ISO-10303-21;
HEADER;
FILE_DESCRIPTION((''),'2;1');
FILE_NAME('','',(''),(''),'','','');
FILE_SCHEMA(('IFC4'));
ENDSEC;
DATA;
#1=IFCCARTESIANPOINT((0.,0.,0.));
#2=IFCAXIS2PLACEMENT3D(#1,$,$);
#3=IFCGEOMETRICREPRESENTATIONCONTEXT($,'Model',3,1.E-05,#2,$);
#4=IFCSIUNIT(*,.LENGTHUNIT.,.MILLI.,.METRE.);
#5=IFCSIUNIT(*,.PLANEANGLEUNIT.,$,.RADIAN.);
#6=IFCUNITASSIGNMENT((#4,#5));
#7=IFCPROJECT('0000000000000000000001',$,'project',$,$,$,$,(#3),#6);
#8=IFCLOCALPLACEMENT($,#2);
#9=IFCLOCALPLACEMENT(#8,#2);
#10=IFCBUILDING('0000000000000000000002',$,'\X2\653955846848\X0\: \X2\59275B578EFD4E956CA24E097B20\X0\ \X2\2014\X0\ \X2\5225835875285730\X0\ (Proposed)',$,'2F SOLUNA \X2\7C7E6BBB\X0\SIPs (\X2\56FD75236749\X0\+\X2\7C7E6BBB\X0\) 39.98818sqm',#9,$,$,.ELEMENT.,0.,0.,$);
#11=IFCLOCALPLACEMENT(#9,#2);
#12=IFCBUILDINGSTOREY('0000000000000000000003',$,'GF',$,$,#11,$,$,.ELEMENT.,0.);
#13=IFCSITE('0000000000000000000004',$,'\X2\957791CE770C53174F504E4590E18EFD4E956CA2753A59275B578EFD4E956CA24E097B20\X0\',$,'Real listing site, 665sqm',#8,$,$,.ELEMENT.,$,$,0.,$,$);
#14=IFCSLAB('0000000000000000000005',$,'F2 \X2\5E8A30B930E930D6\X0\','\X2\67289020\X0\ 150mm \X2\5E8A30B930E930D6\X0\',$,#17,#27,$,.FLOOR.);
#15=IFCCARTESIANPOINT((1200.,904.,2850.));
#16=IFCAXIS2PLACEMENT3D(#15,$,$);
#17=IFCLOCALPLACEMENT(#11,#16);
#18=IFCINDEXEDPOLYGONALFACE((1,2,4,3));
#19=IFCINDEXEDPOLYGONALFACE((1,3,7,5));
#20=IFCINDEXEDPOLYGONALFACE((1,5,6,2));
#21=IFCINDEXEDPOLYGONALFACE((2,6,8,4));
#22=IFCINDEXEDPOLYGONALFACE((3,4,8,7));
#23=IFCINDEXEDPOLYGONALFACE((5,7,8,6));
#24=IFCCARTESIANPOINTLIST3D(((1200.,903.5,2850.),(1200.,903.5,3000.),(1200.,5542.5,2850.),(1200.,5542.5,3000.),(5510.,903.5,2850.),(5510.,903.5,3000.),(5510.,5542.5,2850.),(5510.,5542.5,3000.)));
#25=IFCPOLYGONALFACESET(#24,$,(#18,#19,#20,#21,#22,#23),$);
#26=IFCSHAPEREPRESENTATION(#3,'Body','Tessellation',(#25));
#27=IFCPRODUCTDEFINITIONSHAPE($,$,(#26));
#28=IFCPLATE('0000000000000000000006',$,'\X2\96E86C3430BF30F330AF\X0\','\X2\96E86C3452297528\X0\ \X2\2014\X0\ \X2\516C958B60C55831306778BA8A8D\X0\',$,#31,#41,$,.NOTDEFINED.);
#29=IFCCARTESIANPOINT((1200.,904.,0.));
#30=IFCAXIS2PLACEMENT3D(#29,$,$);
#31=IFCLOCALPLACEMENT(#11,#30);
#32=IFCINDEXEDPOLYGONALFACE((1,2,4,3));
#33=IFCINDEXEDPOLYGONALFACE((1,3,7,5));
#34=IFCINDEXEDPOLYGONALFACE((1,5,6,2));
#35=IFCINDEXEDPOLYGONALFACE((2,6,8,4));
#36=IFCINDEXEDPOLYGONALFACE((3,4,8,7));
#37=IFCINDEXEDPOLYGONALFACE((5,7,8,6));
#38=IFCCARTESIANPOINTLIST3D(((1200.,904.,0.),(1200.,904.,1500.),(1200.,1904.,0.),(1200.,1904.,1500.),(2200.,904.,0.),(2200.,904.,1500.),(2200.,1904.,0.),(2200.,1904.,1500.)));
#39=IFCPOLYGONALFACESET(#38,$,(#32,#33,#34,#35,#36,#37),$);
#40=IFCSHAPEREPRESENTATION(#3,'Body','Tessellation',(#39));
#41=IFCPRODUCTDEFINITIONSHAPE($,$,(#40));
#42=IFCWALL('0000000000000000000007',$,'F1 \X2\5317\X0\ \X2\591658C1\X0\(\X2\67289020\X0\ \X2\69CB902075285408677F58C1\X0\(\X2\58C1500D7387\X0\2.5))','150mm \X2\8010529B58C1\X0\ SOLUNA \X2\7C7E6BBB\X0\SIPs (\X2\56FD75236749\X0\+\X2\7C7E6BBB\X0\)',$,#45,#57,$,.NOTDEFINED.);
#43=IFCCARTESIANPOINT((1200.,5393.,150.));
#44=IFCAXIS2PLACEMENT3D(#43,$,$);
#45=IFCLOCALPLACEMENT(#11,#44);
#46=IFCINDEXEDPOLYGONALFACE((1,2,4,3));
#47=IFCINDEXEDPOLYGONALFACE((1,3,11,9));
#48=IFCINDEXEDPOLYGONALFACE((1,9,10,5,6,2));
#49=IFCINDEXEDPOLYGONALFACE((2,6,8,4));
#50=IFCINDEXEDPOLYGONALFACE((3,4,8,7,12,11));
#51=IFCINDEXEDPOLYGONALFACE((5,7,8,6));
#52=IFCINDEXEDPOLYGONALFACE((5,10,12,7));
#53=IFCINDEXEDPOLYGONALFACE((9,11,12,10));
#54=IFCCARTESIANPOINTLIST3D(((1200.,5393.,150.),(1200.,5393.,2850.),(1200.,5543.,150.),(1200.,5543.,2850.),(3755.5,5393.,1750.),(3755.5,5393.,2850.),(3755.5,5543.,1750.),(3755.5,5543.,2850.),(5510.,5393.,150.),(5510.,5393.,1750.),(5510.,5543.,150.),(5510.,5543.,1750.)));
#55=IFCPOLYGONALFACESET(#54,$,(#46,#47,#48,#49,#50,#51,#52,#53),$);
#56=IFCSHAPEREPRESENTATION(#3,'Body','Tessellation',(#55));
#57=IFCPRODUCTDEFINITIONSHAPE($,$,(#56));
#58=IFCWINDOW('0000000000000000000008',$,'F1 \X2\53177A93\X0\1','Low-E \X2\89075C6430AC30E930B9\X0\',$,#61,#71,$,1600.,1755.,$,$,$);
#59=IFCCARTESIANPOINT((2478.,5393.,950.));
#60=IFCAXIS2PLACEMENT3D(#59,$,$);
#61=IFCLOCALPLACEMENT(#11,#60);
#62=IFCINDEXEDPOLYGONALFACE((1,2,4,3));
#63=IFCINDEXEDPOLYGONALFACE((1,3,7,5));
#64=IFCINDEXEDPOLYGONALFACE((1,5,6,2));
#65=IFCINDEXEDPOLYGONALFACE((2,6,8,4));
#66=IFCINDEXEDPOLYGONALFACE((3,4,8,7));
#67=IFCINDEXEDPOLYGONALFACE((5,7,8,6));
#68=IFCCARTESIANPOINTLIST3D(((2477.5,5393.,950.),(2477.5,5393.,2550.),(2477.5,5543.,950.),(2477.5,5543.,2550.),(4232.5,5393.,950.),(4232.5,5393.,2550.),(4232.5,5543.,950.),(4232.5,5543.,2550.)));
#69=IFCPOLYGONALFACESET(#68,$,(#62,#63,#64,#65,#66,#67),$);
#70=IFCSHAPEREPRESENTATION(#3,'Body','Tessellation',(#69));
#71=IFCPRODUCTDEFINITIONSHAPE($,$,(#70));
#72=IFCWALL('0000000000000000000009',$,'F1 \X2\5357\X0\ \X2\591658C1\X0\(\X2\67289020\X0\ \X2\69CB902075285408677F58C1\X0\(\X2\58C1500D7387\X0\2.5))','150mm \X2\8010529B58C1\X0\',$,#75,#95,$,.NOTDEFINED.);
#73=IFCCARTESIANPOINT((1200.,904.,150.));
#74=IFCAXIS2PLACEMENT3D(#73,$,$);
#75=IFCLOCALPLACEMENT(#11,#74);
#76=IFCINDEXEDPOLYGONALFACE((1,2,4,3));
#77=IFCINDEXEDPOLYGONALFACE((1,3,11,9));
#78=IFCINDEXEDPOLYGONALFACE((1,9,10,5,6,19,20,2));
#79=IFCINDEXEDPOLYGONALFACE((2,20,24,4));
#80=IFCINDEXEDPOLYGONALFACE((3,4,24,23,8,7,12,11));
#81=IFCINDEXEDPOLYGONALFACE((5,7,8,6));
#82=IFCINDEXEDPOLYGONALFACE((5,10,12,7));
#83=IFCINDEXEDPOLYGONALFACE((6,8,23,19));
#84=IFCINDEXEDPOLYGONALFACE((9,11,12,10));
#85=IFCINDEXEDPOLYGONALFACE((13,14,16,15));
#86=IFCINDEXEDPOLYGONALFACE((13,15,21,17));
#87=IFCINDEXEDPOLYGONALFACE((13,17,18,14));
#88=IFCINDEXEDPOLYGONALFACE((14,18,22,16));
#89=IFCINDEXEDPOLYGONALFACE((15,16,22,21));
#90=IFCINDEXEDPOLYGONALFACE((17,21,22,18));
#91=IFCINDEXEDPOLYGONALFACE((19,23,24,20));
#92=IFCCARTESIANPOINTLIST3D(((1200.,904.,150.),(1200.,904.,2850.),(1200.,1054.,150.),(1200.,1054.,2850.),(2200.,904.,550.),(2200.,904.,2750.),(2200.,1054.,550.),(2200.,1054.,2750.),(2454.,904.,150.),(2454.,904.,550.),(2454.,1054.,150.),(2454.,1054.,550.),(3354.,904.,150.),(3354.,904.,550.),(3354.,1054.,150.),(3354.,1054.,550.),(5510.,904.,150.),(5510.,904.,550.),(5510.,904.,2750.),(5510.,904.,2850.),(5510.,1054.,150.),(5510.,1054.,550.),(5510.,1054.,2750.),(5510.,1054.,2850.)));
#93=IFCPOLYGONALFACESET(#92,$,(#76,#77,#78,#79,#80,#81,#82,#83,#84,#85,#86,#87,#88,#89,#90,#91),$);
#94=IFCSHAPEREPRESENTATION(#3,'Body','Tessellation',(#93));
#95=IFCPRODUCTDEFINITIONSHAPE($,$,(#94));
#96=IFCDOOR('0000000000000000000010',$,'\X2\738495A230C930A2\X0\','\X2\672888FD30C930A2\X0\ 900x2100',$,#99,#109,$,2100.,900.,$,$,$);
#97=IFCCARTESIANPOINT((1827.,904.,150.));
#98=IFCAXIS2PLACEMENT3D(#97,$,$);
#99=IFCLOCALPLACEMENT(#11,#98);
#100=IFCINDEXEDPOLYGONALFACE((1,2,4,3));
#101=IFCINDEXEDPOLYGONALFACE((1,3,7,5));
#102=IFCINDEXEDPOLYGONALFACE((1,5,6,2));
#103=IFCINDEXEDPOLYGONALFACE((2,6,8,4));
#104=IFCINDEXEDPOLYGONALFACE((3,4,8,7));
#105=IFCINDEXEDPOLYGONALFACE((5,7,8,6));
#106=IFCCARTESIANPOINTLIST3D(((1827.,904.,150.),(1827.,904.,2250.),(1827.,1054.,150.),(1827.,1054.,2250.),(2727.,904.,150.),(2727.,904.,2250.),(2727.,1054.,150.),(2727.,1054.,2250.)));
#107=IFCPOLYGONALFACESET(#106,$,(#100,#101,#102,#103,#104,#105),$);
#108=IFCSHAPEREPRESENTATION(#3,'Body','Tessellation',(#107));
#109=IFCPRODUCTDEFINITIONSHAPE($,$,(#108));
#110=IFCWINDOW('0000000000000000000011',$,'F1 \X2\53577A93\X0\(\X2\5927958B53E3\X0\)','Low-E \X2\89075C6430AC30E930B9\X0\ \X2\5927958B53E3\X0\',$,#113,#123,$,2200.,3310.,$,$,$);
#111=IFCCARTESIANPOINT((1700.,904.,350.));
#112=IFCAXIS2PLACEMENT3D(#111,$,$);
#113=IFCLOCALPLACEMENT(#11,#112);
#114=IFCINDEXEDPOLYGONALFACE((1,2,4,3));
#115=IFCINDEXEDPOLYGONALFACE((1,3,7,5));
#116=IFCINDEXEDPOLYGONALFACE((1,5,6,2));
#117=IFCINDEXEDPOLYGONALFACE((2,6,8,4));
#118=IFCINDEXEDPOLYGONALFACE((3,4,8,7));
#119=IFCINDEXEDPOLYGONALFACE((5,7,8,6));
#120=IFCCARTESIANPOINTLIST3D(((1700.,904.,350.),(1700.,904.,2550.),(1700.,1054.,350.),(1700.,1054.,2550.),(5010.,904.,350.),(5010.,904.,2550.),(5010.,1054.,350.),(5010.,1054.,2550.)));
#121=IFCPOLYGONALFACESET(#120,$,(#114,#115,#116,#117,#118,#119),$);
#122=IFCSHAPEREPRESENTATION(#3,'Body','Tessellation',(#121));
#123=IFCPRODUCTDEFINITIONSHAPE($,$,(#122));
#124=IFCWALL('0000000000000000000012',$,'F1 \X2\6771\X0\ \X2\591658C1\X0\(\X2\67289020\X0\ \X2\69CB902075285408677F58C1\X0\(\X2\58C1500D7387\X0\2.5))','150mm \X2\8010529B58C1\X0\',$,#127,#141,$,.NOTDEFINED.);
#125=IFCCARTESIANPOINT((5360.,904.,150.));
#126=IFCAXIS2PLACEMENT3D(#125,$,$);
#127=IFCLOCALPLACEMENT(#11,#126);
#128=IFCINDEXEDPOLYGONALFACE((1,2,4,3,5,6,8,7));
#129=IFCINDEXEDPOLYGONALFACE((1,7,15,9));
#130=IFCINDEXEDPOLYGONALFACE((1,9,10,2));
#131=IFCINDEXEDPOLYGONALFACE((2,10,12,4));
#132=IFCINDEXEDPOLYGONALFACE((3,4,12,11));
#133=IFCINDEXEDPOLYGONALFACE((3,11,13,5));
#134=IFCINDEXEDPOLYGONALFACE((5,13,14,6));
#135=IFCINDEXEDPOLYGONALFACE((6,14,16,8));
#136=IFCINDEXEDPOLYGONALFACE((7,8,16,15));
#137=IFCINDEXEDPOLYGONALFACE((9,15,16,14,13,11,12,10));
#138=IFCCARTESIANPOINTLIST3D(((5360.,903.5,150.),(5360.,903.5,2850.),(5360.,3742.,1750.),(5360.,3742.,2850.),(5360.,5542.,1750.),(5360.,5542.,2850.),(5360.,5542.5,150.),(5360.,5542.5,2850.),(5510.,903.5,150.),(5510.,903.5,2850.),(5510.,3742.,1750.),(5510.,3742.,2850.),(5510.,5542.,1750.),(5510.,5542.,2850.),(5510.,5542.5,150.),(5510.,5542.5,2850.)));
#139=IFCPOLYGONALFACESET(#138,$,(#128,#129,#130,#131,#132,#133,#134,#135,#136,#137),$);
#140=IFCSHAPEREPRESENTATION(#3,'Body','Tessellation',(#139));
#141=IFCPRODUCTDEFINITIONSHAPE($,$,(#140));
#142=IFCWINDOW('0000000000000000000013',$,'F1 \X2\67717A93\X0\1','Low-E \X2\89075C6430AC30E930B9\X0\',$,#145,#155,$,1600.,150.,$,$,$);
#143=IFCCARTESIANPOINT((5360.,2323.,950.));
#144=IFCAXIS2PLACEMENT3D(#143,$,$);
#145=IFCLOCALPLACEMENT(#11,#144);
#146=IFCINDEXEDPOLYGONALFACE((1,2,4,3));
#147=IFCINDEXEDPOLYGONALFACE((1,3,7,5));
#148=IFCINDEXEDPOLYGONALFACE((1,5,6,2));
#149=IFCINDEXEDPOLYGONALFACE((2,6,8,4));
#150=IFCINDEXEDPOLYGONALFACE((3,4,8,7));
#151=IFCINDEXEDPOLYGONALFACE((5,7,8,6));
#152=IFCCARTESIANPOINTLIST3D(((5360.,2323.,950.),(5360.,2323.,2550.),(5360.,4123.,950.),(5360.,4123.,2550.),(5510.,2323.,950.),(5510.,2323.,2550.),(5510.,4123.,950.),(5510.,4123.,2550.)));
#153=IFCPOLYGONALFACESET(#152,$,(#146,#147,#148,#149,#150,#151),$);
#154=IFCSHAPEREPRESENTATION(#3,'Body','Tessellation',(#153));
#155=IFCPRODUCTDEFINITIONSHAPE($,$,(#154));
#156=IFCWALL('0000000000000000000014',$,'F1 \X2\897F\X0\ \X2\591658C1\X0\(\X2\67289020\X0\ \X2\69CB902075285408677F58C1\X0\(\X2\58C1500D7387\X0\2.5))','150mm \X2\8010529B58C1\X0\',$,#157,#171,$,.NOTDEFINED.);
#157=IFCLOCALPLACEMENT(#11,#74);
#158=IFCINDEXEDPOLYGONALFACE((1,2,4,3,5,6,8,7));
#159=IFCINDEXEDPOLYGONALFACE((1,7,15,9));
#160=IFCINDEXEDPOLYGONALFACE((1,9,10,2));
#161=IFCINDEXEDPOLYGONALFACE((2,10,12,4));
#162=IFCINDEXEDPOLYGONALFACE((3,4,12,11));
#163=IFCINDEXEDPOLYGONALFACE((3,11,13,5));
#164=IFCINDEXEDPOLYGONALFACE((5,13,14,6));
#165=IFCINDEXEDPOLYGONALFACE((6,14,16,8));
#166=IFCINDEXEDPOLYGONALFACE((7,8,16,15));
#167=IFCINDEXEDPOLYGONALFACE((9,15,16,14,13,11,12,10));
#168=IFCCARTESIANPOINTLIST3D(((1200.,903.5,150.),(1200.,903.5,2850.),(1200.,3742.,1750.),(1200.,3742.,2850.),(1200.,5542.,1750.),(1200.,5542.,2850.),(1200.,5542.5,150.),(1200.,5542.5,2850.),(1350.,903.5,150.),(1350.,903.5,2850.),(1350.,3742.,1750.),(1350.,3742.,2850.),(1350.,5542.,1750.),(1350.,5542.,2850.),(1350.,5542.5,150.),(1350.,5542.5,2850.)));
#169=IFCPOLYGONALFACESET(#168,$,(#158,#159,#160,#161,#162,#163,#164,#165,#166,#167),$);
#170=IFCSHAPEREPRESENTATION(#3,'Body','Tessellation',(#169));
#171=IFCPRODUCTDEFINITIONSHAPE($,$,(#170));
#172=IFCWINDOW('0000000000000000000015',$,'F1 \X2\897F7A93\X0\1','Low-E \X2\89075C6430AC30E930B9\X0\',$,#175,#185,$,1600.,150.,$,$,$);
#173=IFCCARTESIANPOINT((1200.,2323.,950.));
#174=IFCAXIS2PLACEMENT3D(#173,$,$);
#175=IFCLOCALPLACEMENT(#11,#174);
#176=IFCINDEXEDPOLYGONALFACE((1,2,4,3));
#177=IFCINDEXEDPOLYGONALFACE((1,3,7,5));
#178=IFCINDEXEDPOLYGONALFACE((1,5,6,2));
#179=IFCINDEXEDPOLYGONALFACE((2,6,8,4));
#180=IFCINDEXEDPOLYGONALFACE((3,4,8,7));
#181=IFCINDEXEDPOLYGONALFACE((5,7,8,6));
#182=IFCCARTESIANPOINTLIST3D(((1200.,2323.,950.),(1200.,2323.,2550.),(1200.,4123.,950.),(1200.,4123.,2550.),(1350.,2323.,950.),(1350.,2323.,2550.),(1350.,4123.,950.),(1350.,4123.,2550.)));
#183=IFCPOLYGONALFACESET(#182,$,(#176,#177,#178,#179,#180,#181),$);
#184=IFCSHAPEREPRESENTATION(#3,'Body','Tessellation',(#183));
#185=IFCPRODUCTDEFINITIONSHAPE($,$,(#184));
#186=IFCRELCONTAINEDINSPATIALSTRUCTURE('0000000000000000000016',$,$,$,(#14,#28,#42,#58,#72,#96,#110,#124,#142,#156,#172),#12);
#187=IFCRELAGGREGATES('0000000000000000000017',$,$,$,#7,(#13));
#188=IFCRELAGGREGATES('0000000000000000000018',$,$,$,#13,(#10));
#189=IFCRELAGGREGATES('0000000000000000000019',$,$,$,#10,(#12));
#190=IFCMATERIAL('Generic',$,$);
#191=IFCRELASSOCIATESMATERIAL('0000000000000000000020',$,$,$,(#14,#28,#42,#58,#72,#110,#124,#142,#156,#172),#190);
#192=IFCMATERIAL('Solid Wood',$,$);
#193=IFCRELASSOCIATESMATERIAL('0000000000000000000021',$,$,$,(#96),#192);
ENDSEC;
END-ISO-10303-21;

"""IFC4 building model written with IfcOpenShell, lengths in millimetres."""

from ifc_helpers import new_model, si_unit, frame, frame_2d, origin, place, context, project, spatial, rectangle, extrude, material, element, fill, save


model = new_model("IFC4")

# Units and contexts
model_context = context("Model", 3, precision=1e-05, world=origin())
ifc_project = project(units=[si_unit("LENGTHUNIT", "METRE", prefix="MILLI"), si_unit("PLANEANGLEUNIT", "RADIAN")], contexts=[model_context])

# Site, building, storey
site_placement = place(None, origin())
site = spatial("IfcSite", under=ifc_project, at=site_placement, Name="長野県北佐久郡軽井沢町大字軽井沢三笠", ObjectType="Real listing site, 665sqm", CompositionType="ELEMENT", RefElevation=0.0)
building_placement = place(site_placement, origin())
building = spatial("IfcBuilding", under=site, at=building_placement, Name="改善案: 大字軽井沢三笠 — 別荘用地 (Proposed)", ObjectType="2F SOLUNA 籾殻SIPs (国産杉+籾殻) 39.98818sqm", CompositionType="ELEMENT", ElevationOfRefHeight=0.0, ElevationOfTerrain=0.0)
storey_placement = place(building_placement, origin())
storey = spatial("IfcBuildingStorey", under=building, at=storey_placement, Name="GF", CompositionType="ELEMENT", Elevation=0.0)

# Slab
ifc_material_1 = material(Name="Generic")
slab_1_placement = place(storey_placement, frame((1200.0, 904.0, 2850.0)))
element("IfcSlab", 1, at=slab_1_placement, inside=storey, material=ifc_material_1, Name="F2 床スラブ", Description="木造 150mm 床スラブ", PredefinedType="FLOOR", context=model_context, shape_type="SweptSolid", body=[
    extrude(rectangle(XDim=4310.0, YDim=4639.0, at=frame_2d((2155.0, 2319.0))), frame((1200.0, 904.0, 2850.0)), (0.0, 0.0, 1.0), 150.0),
])

# Plate
plate_placement = place(storey_placement, frame((1200.0, 904.0, 0.0)))
element("IfcPlate", 2, at=plate_placement, inside=storey, material=ifc_material_1, Name="雨水タンク", Description="雨水利用 — 公開情報で確認", PredefinedType="NOTDEFINED", context=model_context, shape_type="SweptSolid", body=[
    extrude(rectangle(XDim=1000.0, YDim=1000.0, at=frame_2d((500.0, 500.0))), frame((1200.0, 904.0, 0.0)), (0.0, 0.0, 1.0), 1500.0),
])

# Wall, opening, window
wall_1_placement = place(storey_placement, frame((1200.0, 5393.0, 150.0)))
wall_1 = element("IfcWall", 3, at=wall_1_placement, inside=storey, material=ifc_material_1, Name="F1 北 外壁(木造 構造用合板壁(壁倍率2.5))", Description="150mm 耐力壁 SOLUNA 籾殻SIPs (国産杉+籾殻)", PredefinedType="NOTDEFINED", context=model_context, shape_type="SweptSolid", body=[
    extrude(rectangle(XDim=4310.0, YDim=150.0, at=frame_2d((2155.0, 75.0))), frame((1200.0, 5393.0, 150.0)), (0.0, 0.0, 1.0), 2700.0),
])
opening_1_placement = place(storey_placement, frame((2478.0, 5393.0, 950.0)))
opening_1 = element("IfcOpeningElement", 4, at=opening_1_placement, cuts=wall_1, PredefinedType="NOTDEFINED", context=model_context, shape_type="SweptSolid", body=[
    extrude(rectangle(XDim=1755.0, YDim=150.0, at=frame_2d((877.0, 75.0))), frame((2478.0, 5393.0, 950.0)), (0.0, 0.0, 1.0), 1600.0),
])
window_1_placement = place(storey_placement, frame((2478.0, 5393.0, 950.0)))
window_1 = element("IfcWindow", 5, at=window_1_placement, inside=storey, material=ifc_material_1, Name="F1 北窓1", Description="Low-E 複層ガラス", OverallHeight=1600.0, OverallWidth=1755.0, context=model_context, shape_type="SweptSolid", body=[
    extrude(rectangle(XDim=1755.0, YDim=150.0, at=frame_2d((877.0, 75.0))), frame((2478.0, 5393.0, 950.0)), (0.0, 0.0, 1.0), 1600.0),
])
fill(opening_1, window_1)

# Wall, openings, door, window
wall_2_placement = place(storey_placement, frame((1200.0, 904.0, 150.0)))
wall_2 = element("IfcWall", 6, at=wall_2_placement, inside=storey, material=ifc_material_1, Name="F1 南 外壁(木造 構造用合板壁(壁倍率2.5))", Description="150mm 耐力壁", PredefinedType="NOTDEFINED", context=model_context, shape_type="SweptSolid", body=[
    extrude(rectangle(XDim=4310.0, YDim=150.0, at=frame_2d((2155.0, 75.0))), frame((1200.0, 904.0, 150.0)), (0.0, 0.0, 1.0), 2700.0),
])
opening_2_placement = place(storey_placement, frame((1827.0, 904.0, 150.0)))
opening_2 = element("IfcOpeningElement", 7, at=opening_2_placement, cuts=wall_2, PredefinedType="NOTDEFINED", context=model_context, shape_type="SweptSolid", body=[
    extrude(rectangle(XDim=900.0, YDim=150.0, at=frame_2d((450.0, 75.0))), frame((1827.0, 904.0, 150.0)), (0.0, 0.0, 1.0), 2100.0),
])
opening_3_placement = place(storey_placement, frame((1700.0, 904.0, 350.0)))
opening_3 = element("IfcOpeningElement", 8, at=opening_3_placement, cuts=wall_2, PredefinedType="NOTDEFINED", context=model_context, shape_type="SweptSolid", body=[
    extrude(rectangle(XDim=3310.0, YDim=150.0, at=frame_2d((1655.0, 75.0))), frame((1700.0, 904.0, 350.0)), (0.0, 0.0, 1.0), 2200.0),
])
ifc_material_2 = material(Name="Solid Wood")
door_placement = place(storey_placement, frame((1827.0, 904.0, 150.0)))
door = element("IfcDoor", 9, at=door_placement, inside=storey, material=ifc_material_2, Name="玄関ドア", Description="木製ドア 900x2100", OverallHeight=2100.0, OverallWidth=900.0, context=model_context, shape_type="SweptSolid", body=[
    extrude(rectangle(XDim=900.0, YDim=150.0, at=frame_2d((450.0, 75.0))), frame((1827.0, 904.0, 150.0)), (0.0, 0.0, 1.0), 2100.0),
])
fill(opening_2, door)
window_2_placement = place(storey_placement, frame((1700.0, 904.0, 350.0)))
window_2 = element("IfcWindow", 10, at=window_2_placement, inside=storey, material=ifc_material_1, Name="F1 南窓(大開口)", Description="Low-E 複層ガラス 大開口", OverallHeight=2200.0, OverallWidth=3310.0, context=model_context, shape_type="SweptSolid", body=[
    extrude(rectangle(XDim=3310.0, YDim=150.0, at=frame_2d((1655.0, 75.0))), frame((1700.0, 904.0, 350.0)), (0.0, 0.0, 1.0), 2200.0),
])
fill(opening_3, window_2)

# Walls, openings, windows
wall_3_placement = place(storey_placement, frame((5360.0, 904.0, 150.0)))
wall_3 = element("IfcWall", 11, at=wall_3_placement, inside=storey, material=ifc_material_1, Name="F1 東 外壁(木造 構造用合板壁(壁倍率2.5))", Description="150mm 耐力壁", PredefinedType="NOTDEFINED", context=model_context, shape_type="SweptSolid", body=[
    extrude(rectangle(XDim=150.0, YDim=4639.0, at=frame_2d((75.0, 2319.0))), frame((5360.0, 904.0, 150.0)), (0.0, 0.0, 1.0), 2700.0),
])
opening_4_placement = place(storey_placement, frame((5360.0, 2323.0, 950.0)))
opening_4 = element("IfcOpeningElement", 12, at=opening_4_placement, cuts=wall_3, PredefinedType="NOTDEFINED", context=model_context, shape_type="SweptSolid", body=[
    extrude(rectangle(XDim=150.0, YDim=1800.0, at=frame_2d((75.0, 900.0))), frame((5360.0, 2323.0, 950.0)), (0.0, 0.0, 1.0), 1600.0),
])
window_3_placement = place(storey_placement, frame((5360.0, 2323.0, 950.0)))
window_3 = element("IfcWindow", 13, at=window_3_placement, inside=storey, material=ifc_material_1, Name="F1 東窓1", Description="Low-E 複層ガラス", OverallHeight=1600.0, OverallWidth=150.0, context=model_context, shape_type="SweptSolid", body=[
    extrude(rectangle(XDim=150.0, YDim=1800.0, at=frame_2d((75.0, 900.0))), frame((5360.0, 2323.0, 950.0)), (0.0, 0.0, 1.0), 1600.0),
])
fill(opening_4, window_3)
wall_4_placement = place(storey_placement, frame((1200.0, 904.0, 150.0)))
wall_4 = element("IfcWall", 14, at=wall_4_placement, inside=storey, material=ifc_material_1, Name="F1 西 外壁(木造 構造用合板壁(壁倍率2.5))", Description="150mm 耐力壁", PredefinedType="NOTDEFINED", context=model_context, shape_type="SweptSolid", body=[
    extrude(rectangle(XDim=150.0, YDim=4639.0, at=frame_2d((75.0, 2319.0))), frame((1200.0, 904.0, 150.0)), (0.0, 0.0, 1.0), 2700.0),
])
opening_5_placement = place(storey_placement, frame((1200.0, 2323.0, 950.0)))
opening_5 = element("IfcOpeningElement", 15, at=opening_5_placement, cuts=wall_4, PredefinedType="NOTDEFINED", context=model_context, shape_type="SweptSolid", body=[
    extrude(rectangle(XDim=150.0, YDim=1800.0, at=frame_2d((75.0, 900.0))), frame((1200.0, 2323.0, 950.0)), (0.0, 0.0, 1.0), 1600.0),
])
window_4_placement = place(storey_placement, frame((1200.0, 2323.0, 950.0)))
window_4 = element("IfcWindow", 16, at=window_4_placement, inside=storey, material=ifc_material_1, Name="F1 西窓1", Description="Low-E 複層ガラス", OverallHeight=1600.0, OverallWidth=150.0, context=model_context, shape_type="SweptSolid", body=[
    extrude(rectangle(XDim=150.0, YDim=1800.0, at=frame_2d((75.0, 900.0))), frame((1200.0, 2323.0, 950.0)), (0.0, 0.0, 1.0), 1600.0),
])
fill(opening_5, window_4)

save(model, "model.ifc")
